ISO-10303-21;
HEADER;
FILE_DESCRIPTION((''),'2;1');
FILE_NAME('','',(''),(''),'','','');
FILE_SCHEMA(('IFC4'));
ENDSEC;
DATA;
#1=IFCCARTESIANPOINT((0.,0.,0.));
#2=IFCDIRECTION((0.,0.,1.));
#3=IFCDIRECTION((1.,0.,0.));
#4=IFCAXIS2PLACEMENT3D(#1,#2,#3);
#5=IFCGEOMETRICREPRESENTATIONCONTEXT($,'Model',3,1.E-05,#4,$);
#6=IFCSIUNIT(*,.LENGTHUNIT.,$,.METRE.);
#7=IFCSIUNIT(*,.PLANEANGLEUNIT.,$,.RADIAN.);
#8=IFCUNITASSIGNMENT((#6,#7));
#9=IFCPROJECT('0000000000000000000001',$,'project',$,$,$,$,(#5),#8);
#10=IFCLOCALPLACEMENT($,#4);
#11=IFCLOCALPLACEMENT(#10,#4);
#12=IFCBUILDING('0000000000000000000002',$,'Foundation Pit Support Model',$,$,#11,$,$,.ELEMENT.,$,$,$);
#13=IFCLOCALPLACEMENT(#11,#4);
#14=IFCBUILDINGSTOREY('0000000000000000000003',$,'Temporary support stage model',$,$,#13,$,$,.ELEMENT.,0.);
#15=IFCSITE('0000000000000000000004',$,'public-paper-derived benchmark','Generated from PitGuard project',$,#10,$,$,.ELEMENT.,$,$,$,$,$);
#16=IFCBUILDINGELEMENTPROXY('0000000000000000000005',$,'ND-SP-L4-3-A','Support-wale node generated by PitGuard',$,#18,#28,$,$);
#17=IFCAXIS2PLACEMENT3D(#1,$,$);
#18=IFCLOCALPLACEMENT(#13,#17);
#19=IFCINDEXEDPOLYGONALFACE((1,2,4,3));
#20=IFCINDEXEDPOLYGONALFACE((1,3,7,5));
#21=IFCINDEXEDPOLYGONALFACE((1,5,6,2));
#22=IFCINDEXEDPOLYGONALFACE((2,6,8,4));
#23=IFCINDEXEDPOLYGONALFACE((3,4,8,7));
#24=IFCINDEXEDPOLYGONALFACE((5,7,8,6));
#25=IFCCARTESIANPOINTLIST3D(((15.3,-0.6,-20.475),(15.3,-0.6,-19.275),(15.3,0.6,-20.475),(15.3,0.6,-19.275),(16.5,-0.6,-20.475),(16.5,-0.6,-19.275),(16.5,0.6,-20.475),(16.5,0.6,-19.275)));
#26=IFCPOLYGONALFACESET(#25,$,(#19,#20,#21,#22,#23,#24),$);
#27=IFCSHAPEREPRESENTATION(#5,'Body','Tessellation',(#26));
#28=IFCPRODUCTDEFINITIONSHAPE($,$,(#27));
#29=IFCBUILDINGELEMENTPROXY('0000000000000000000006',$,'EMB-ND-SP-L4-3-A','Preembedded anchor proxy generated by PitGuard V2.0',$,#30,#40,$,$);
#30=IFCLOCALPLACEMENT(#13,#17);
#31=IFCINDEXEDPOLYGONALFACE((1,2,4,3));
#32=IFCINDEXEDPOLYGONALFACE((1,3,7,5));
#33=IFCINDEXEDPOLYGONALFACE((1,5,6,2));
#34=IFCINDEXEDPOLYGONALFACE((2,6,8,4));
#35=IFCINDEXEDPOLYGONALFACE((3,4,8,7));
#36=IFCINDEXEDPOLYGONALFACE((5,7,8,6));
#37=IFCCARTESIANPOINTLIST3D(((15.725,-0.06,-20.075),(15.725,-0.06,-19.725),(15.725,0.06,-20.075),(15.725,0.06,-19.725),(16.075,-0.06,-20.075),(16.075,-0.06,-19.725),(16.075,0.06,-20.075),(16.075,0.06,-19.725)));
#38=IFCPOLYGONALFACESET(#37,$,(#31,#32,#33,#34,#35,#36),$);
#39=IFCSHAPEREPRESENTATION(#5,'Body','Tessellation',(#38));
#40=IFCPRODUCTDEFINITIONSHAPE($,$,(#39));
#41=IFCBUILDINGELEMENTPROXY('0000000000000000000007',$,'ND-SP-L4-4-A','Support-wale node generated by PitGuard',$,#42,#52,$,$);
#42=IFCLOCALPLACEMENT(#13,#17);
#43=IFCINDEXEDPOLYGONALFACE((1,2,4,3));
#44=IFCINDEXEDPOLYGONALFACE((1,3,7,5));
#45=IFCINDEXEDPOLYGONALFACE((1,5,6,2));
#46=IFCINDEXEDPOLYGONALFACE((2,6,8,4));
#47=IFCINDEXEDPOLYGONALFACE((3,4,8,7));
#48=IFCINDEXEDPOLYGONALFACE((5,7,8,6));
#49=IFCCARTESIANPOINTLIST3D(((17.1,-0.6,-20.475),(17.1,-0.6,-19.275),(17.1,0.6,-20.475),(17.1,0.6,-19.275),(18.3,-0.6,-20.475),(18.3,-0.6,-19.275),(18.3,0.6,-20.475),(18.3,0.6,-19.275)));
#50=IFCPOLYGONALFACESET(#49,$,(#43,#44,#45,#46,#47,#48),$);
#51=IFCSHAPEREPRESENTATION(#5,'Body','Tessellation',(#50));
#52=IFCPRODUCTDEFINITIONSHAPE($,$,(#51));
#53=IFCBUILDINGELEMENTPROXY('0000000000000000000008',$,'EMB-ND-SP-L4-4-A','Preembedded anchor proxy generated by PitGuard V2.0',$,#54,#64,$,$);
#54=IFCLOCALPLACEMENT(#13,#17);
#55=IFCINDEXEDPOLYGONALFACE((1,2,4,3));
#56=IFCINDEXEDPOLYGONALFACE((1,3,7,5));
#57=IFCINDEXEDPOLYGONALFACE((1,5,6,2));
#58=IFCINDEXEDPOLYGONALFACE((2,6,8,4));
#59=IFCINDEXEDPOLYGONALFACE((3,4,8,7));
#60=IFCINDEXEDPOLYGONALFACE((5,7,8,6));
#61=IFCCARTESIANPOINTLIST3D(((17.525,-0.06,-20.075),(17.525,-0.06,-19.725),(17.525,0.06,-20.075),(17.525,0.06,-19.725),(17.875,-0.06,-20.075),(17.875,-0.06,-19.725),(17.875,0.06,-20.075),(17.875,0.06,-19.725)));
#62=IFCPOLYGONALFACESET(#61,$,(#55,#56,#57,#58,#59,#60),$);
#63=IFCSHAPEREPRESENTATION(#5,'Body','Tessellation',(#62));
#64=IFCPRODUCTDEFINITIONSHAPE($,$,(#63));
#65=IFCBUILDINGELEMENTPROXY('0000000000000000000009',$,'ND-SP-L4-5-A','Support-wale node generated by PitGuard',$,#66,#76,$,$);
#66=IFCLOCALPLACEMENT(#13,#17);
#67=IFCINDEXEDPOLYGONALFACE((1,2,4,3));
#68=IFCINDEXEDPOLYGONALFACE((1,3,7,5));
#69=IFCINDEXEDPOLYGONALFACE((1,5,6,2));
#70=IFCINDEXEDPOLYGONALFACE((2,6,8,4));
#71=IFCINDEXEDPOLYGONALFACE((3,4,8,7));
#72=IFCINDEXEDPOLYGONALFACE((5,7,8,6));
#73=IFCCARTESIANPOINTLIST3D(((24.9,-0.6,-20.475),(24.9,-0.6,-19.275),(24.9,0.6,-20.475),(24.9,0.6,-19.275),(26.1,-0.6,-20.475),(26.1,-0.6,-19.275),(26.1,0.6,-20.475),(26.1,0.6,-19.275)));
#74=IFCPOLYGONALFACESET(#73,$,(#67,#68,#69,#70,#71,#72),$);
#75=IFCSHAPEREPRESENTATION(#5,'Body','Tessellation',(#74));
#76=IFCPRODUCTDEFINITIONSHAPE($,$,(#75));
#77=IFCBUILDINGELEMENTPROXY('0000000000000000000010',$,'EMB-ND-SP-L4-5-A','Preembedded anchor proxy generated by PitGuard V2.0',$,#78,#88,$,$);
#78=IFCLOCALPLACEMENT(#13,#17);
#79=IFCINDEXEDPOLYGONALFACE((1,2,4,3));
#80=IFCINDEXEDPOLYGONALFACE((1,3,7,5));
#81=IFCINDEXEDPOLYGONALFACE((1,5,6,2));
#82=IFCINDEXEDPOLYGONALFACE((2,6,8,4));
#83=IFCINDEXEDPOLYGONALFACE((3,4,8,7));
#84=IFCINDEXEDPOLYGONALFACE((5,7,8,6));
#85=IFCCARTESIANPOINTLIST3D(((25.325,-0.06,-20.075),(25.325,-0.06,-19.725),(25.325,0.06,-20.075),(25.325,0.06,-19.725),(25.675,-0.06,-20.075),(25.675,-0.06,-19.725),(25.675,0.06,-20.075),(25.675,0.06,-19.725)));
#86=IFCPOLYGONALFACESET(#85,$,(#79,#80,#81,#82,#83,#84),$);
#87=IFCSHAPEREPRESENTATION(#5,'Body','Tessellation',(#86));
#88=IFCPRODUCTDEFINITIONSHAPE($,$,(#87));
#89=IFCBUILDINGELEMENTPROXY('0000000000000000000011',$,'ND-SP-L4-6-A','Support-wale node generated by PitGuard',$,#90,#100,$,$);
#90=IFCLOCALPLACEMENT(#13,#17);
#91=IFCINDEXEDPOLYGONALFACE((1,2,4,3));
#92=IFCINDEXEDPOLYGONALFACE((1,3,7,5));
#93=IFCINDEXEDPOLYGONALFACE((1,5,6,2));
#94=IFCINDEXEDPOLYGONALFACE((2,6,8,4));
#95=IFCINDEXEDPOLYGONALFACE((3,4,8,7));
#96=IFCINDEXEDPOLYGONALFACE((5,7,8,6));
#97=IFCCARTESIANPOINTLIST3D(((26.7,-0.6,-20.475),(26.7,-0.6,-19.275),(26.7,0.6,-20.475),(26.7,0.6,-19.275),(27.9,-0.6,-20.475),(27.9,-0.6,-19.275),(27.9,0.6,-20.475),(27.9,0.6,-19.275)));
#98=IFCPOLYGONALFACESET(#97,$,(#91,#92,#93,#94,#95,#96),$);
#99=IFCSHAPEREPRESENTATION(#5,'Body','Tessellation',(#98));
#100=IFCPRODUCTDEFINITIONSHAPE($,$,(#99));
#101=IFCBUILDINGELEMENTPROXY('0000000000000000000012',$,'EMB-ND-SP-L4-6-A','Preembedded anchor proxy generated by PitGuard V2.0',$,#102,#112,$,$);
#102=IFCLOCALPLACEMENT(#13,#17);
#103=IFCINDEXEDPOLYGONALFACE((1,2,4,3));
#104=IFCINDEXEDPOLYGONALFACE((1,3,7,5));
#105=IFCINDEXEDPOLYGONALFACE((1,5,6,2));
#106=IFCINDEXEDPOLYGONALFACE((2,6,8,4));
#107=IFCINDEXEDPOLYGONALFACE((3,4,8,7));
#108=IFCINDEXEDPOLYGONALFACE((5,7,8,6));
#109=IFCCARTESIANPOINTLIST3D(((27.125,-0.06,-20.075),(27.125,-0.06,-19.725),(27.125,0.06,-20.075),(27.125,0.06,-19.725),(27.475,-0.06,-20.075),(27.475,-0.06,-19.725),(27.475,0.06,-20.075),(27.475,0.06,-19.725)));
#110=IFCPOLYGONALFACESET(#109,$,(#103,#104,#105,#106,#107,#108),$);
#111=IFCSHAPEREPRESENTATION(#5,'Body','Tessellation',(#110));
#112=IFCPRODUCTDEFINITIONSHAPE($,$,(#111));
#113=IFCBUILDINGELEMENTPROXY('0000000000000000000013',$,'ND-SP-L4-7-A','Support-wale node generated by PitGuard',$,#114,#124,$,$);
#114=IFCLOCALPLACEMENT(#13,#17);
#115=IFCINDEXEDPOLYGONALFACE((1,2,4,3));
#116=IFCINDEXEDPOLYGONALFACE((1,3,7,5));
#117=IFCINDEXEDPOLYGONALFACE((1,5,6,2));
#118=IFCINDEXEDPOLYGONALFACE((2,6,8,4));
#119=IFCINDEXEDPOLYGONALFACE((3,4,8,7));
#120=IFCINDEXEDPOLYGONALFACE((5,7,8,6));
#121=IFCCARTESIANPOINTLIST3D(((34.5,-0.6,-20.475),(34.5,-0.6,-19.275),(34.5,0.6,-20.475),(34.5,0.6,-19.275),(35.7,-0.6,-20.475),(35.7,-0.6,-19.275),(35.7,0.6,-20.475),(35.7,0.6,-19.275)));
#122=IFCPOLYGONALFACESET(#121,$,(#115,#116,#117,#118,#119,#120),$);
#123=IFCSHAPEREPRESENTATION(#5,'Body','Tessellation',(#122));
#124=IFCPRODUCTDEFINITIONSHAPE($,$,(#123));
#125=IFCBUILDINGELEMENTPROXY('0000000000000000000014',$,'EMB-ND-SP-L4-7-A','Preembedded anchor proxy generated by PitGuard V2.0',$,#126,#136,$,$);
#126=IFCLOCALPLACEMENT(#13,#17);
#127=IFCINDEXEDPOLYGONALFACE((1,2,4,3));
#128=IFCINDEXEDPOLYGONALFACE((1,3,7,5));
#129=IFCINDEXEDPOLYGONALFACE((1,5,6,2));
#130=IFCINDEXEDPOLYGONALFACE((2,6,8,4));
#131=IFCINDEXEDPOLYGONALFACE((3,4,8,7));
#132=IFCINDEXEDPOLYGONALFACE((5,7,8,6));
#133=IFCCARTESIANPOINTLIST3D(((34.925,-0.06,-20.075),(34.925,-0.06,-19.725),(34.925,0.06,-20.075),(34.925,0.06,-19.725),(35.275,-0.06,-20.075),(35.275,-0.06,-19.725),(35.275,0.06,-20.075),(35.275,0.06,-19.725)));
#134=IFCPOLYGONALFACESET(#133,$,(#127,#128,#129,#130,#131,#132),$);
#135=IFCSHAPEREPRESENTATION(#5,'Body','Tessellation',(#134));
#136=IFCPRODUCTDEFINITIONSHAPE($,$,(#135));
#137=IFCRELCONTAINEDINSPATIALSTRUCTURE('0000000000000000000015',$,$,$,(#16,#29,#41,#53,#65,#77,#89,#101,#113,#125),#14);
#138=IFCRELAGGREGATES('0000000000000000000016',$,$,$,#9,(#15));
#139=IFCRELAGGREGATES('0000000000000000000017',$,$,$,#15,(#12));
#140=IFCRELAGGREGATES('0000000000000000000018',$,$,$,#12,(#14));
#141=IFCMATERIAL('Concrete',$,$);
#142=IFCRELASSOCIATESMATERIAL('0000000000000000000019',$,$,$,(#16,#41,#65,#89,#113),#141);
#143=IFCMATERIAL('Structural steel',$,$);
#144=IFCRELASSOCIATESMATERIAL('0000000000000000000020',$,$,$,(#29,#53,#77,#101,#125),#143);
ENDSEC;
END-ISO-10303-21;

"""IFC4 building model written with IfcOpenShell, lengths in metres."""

from ifc_helpers import new_model, si_unit, frame, origin_with_axes, origin_2d, place, context, project, spatial, rectangle, extrude, material, element, save


model = new_model("IFC4")

# Units and contexts
model_context = context("Model", 3, precision=1e-05, world=origin_with_axes())
ifc_project = project(units=[si_unit("LENGTHUNIT", "METRE"), si_unit("PLANEANGLEUNIT", "RADIAN")], contexts=[model_context])

# Site, building, storey
site_placement = place(None, origin_with_axes())
site = spatial("IfcSite", under=ifc_project, at=site_placement, Name="public-paper-derived benchmark", Description="Generated from PitGuard project", CompositionType="ELEMENT")
building_placement = place(site_placement, origin_with_axes())
building = spatial("IfcBuilding", under=site, at=building_placement, Name="Foundation Pit Support Model", CompositionType="ELEMENT")
storey_placement = place(building_placement, origin_with_axes())
storey = spatial("IfcBuildingStorey", under=building, at=storey_placement, Name="Temporary support stage model", CompositionType="ELEMENT", Elevation=0.0)

# Shared definitions
ifc_material_1 = material(Name="Concrete")

# Shared definitions
ifc_material_2 = material(Name="Structural steel")

# Building element proxies
proxy_1_placement = place(storey_placement, frame((15.9, 0.0, -20.475), z_axis=(0.0, 0.0, 1.0), x_axis=(1.0, 0.0, 0.0)))
element("IfcBuildingElementProxy", 1, at=proxy_1_placement, inside=storey, material=ifc_material_1, Name="ND-SP-L4-3-A", Description="Support-wale node generated by PitGuard", context=model_context, shape_type="SweptSolid", body=[
    extrude(rectangle(XDim=1.2, YDim=1.2, at=origin_2d()), origin_with_axes(), (0.0, 0.0, 1.0), 1.2),
])
proxy_2_placement = place(storey_placement, frame((15.9, 0.0, -20.075), z_axis=(0.0, 0.0, 1.0), x_axis=(1.0, 0.0, 0.0)))
element("IfcBuildingElementProxy", 2, at=proxy_2_placement, inside=storey, material=ifc_material_2, Name="EMB-ND-SP-L4-3-A", Description="Preembedded anchor proxy generated by PitGuard V2.0", context=model_context, shape_type="SweptSolid", body=[
    extrude(rectangle(XDim=0.35, YDim=0.12, at=origin_2d()), origin_with_axes(), (0.0, 0.0, 1.0), 0.35),
])
proxy_3_placement = place(storey_placement, frame((17.7, 0.0, -20.475), z_axis=(0.0, 0.0, 1.0), x_axis=(1.0, 0.0, 0.0)))
element("IfcBuildingElementProxy", 3, at=proxy_3_placement, inside=storey, material=ifc_material_1, Name="ND-SP-L4-4-A", Description="Support-wale node generated by PitGuard", context=model_context, shape_type="SweptSolid", body=[
    extrude(rectangle(XDim=1.2, YDim=1.2, at=origin_2d()), origin_with_axes(), (0.0, 0.0, 1.0), 1.2),
])
proxy_4_placement = place(storey_placement, frame((17.7, 0.0, -20.075), z_axis=(0.0, 0.0, 1.0), x_axis=(1.0, 0.0, 0.0)))
element("IfcBuildingElementProxy", 4, at=proxy_4_placement, inside=storey, material=ifc_material_2, Name="EMB-ND-SP-L4-4-A", Description="Preembedded anchor proxy generated by PitGuard V2.0", context=model_context, shape_type="SweptSolid", body=[
    extrude(rectangle(XDim=0.35, YDim=0.12, at=origin_2d()), origin_with_axes(), (0.0, 0.0, 1.0), 0.35),
])
proxy_5_placement = place(storey_placement, frame((25.5, 0.0, -20.475), z_axis=(0.0, 0.0, 1.0), x_axis=(1.0, 0.0, 0.0)))
element("IfcBuildingElementProxy", 5, at=proxy_5_placement, inside=storey, material=ifc_material_1, Name="ND-SP-L4-5-A", Description="Support-wale node generated by PitGuard", context=model_context, shape_type="SweptSolid", body=[
    extrude(rectangle(XDim=1.2, YDim=1.2, at=origin_2d()), origin_with_axes(), (0.0, 0.0, 1.0), 1.2),
])
proxy_6_placement = place(storey_placement, frame((25.5, 0.0, -20.075), z_axis=(0.0, 0.0, 1.0), x_axis=(1.0, 0.0, 0.0)))
element("IfcBuildingElementProxy", 6, at=proxy_6_placement, inside=storey, material=ifc_material_2, Name="EMB-ND-SP-L4-5-A", Description="Preembedded anchor proxy generated by PitGuard V2.0", context=model_context, shape_type="SweptSolid", body=[
    extrude(rectangle(XDim=0.35, YDim=0.12, at=origin_2d()), origin_with_axes(), (0.0, 0.0, 1.0), 0.35),
])
proxy_7_placement = place(storey_placement, frame((27.3, 0.0, -20.475), z_axis=(0.0, 0.0, 1.0), x_axis=(1.0, 0.0, 0.0)))
element("IfcBuildingElementProxy", 7, at=proxy_7_placement, inside=storey, material=ifc_material_1, Name="ND-SP-L4-6-A", Description="Support-wale node generated by PitGuard", context=model_context, shape_type="SweptSolid", body=[
    extrude(rectangle(XDim=1.2, YDim=1.2, at=origin_2d()), origin_with_axes(), (0.0, 0.0, 1.0), 1.2),
])
proxy_8_placement = place(storey_placement, frame((27.3, 0.0, -20.075), z_axis=(0.0, 0.0, 1.0), x_axis=(1.0, 0.0, 0.0)))
element("IfcBuildingElementProxy", 8, at=proxy_8_placement, inside=storey, material=ifc_material_2, Name="EMB-ND-SP-L4-6-A", Description="Preembedded anchor proxy generated by PitGuard V2.0", context=model_context, shape_type="SweptSolid", body=[
    extrude(rectangle(XDim=0.35, YDim=0.12, at=origin_2d()), origin_with_axes(), (0.0, 0.0, 1.0), 0.35),
])
proxy_9_placement = place(storey_placement, frame((35.1, 0.0, -20.475), z_axis=(0.0, 0.0, 1.0), x_axis=(1.0, 0.0, 0.0)))
element("IfcBuildingElementProxy", 9, at=proxy_9_placement, inside=storey, material=ifc_material_1, Name="ND-SP-L4-7-A", Description="Support-wale node generated by PitGuard", context=model_context, shape_type="SweptSolid", body=[
    extrude(rectangle(XDim=1.2, YDim=1.2, at=origin_2d()), origin_with_axes(), (0.0, 0.0, 1.0), 1.2),
])
proxy_10_placement = place(storey_placement, frame((35.1, 0.0, -20.075), z_axis=(0.0, 0.0, 1.0), x_axis=(1.0, 0.0, 0.0)))
element("IfcBuildingElementProxy", 10, at=proxy_10_placement, inside=storey, material=ifc_material_2, Name="EMB-ND-SP-L4-7-A", Description="Preembedded anchor proxy generated by PitGuard V2.0", context=model_context, shape_type="SweptSolid", body=[
    extrude(rectangle(XDim=0.35, YDim=0.12, at=origin_2d()), origin_with_axes(), (0.0, 0.0, 1.0), 0.35),
])

save(model, "model.ifc")
